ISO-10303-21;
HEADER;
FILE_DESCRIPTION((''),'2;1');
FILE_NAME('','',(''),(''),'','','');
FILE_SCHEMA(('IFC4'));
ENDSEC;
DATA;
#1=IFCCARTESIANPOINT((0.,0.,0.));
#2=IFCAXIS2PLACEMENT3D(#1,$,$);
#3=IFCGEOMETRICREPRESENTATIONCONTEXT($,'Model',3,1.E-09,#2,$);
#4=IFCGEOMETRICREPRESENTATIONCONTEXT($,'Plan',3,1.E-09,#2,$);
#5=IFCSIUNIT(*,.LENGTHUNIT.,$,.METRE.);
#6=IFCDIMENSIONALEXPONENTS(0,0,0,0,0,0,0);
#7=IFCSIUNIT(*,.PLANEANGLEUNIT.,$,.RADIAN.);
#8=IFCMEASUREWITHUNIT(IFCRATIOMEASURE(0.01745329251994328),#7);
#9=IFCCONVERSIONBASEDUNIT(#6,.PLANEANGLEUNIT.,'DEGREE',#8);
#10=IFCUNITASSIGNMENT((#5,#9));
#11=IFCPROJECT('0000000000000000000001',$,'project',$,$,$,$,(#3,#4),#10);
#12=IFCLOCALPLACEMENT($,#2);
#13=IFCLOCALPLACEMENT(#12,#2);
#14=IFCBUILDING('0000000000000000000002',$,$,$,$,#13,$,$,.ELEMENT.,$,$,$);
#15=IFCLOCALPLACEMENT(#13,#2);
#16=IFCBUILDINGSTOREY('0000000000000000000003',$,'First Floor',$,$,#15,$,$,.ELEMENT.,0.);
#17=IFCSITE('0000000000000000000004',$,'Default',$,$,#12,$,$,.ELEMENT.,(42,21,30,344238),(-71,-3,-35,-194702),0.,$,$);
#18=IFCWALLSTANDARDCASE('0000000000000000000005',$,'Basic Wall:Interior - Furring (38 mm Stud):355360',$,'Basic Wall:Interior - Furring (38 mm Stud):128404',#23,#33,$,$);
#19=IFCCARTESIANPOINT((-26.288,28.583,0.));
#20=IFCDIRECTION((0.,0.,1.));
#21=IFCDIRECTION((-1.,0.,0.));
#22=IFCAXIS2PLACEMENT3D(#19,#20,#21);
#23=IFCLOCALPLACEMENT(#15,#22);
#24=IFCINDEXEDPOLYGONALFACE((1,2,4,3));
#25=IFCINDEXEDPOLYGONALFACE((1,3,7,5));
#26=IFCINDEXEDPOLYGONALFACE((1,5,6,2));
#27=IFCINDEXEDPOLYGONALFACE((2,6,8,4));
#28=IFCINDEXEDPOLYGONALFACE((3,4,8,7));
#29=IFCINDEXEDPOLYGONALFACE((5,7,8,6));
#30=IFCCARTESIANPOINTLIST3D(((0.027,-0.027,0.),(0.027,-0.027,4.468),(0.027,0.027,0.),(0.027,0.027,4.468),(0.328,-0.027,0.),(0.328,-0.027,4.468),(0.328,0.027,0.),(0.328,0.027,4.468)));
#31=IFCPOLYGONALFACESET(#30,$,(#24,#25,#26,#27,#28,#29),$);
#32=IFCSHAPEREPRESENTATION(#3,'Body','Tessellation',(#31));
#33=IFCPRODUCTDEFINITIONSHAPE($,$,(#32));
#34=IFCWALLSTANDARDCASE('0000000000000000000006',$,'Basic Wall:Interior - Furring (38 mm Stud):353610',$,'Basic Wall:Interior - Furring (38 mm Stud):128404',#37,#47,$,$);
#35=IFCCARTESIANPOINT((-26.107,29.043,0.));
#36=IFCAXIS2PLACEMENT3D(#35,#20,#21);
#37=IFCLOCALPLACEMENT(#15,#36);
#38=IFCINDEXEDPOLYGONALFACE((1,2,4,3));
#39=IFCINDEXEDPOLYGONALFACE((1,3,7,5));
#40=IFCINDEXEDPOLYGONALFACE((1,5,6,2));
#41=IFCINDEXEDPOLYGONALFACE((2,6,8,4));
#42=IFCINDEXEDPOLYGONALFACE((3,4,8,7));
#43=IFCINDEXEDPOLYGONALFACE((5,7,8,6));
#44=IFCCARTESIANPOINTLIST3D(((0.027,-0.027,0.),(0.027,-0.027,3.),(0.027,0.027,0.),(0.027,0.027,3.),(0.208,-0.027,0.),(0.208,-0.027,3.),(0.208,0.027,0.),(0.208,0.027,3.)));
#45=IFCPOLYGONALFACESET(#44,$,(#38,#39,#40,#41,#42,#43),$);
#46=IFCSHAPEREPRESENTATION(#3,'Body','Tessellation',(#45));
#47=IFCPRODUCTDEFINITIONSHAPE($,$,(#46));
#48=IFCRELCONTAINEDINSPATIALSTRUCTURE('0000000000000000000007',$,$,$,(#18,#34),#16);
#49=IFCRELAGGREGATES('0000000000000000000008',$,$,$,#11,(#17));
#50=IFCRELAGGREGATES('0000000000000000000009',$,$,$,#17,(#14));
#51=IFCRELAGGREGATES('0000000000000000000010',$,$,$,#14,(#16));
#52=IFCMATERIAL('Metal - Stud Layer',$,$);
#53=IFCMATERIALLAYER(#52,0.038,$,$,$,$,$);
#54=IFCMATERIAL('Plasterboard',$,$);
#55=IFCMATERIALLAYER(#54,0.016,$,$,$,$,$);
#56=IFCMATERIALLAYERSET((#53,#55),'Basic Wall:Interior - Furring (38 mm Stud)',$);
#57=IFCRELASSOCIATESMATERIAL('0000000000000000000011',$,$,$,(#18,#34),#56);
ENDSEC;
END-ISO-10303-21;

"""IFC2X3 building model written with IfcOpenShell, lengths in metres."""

from ifc_helpers import new_model, entity, si_unit, converted_unit, frame, frame_2d, origin, place, context, project, spatial, rectangle, extrude, material, layer, layer_set, layer_usage, element, save


model = new_model("IFC2X3")

# Units and contexts
model_context = context("Model", 3, precision=1e-09, world=origin())
plan_context = context("Plan", 3, precision=1e-09, world=origin())
ifc_project = project(units=[si_unit("LENGTHUNIT", "METRE"), converted_unit("PLANEANGLEUNIT", "DEGREE", entity("IfcRatioMeasure", 0.01745329251994328), si_unit("PLANEANGLEUNIT", "RADIAN"), dimensions=[0, 0, 0, 0, 0, 0, 0])], contexts=[model_context, plan_context])

# Site, building, storey
site_placement = place(None, origin())
site = spatial("IfcSite", under=ifc_project, at=site_placement, Name="Default", CompositionType="ELEMENT", RefLatitude=(42, 21, 30, 344238), RefLongitude=(-71, -3, -35, -194702), RefElevation=0.0)
building_placement = place(site_placement, origin())
building = spatial("IfcBuilding", under=site, at=building_placement, CompositionType="ELEMENT")
storey_placement = place(building_placement, origin())
storey = spatial("IfcBuildingStorey", under=building, at=storey_placement, Name="First Floor", CompositionType="ELEMENT", Elevation=0.0)

# Shared definitions
ifc_material_1 = material(Name="Metal - Stud Layer")
ifc_material_2 = material(Name="Plasterboard")

# Walls
ifc_layer_1 = layer(ifc_material_1, 0.038)
ifc_layer_2 = layer(ifc_material_2, 0.016)
ifc_layer_set_1 = layer_set([ifc_layer_1, ifc_layer_2], Name="Basic Wall:Interior - Furring (38 mm Stud)")
ifc_layer_usage_1 = layer_usage(ifc_layer_set_1, "AXIS2", "NEGATIVE", 0.027)
wall_1_placement = place(storey_placement, frame((-26.288, 28.583, 0.0), z_axis=(0.0, 0.0, 1.0), x_axis=(-1.0, 0.0, 0.0)))
element("IfcWallStandardCase", 1, at=wall_1_placement, inside=storey, material=ifc_layer_usage_1, Name="Basic Wall:Interior - Furring (38 mm Stud):355360", ObjectType="Basic Wall:Interior - Furring (38 mm Stud):128404", context=model_context, shape_type="SweptSolid", body=[
    extrude(rectangle(XDim=0.301, YDim=0.054, at=frame_2d((0.1775, 0.0), x_axis=(-1.0, 0.0))), origin(), (0.0, 0.0, 1.0), 4.468),
])
wall_2_placement = place(storey_placement, frame((-26.107, 29.043, 0.0), z_axis=(0.0, 0.0, 1.0), x_axis=(-1.0, 0.0, 0.0)))
element("IfcWallStandardCase", 2, at=wall_2_placement, inside=storey, material=ifc_layer_usage_1, Name="Basic Wall:Interior - Furring (38 mm Stud):353610", ObjectType="Basic Wall:Interior - Furring (38 mm Stud):128404", context=model_context, shape_type="SweptSolid", body=[
    extrude(rectangle(XDim=0.181, YDim=0.054, at=frame_2d((0.1175, 0.0), x_axis=(-1.0, 0.0))), origin(), (0.0, 0.0, 1.0), 3.0),
])

save(model, "model.ifc")
